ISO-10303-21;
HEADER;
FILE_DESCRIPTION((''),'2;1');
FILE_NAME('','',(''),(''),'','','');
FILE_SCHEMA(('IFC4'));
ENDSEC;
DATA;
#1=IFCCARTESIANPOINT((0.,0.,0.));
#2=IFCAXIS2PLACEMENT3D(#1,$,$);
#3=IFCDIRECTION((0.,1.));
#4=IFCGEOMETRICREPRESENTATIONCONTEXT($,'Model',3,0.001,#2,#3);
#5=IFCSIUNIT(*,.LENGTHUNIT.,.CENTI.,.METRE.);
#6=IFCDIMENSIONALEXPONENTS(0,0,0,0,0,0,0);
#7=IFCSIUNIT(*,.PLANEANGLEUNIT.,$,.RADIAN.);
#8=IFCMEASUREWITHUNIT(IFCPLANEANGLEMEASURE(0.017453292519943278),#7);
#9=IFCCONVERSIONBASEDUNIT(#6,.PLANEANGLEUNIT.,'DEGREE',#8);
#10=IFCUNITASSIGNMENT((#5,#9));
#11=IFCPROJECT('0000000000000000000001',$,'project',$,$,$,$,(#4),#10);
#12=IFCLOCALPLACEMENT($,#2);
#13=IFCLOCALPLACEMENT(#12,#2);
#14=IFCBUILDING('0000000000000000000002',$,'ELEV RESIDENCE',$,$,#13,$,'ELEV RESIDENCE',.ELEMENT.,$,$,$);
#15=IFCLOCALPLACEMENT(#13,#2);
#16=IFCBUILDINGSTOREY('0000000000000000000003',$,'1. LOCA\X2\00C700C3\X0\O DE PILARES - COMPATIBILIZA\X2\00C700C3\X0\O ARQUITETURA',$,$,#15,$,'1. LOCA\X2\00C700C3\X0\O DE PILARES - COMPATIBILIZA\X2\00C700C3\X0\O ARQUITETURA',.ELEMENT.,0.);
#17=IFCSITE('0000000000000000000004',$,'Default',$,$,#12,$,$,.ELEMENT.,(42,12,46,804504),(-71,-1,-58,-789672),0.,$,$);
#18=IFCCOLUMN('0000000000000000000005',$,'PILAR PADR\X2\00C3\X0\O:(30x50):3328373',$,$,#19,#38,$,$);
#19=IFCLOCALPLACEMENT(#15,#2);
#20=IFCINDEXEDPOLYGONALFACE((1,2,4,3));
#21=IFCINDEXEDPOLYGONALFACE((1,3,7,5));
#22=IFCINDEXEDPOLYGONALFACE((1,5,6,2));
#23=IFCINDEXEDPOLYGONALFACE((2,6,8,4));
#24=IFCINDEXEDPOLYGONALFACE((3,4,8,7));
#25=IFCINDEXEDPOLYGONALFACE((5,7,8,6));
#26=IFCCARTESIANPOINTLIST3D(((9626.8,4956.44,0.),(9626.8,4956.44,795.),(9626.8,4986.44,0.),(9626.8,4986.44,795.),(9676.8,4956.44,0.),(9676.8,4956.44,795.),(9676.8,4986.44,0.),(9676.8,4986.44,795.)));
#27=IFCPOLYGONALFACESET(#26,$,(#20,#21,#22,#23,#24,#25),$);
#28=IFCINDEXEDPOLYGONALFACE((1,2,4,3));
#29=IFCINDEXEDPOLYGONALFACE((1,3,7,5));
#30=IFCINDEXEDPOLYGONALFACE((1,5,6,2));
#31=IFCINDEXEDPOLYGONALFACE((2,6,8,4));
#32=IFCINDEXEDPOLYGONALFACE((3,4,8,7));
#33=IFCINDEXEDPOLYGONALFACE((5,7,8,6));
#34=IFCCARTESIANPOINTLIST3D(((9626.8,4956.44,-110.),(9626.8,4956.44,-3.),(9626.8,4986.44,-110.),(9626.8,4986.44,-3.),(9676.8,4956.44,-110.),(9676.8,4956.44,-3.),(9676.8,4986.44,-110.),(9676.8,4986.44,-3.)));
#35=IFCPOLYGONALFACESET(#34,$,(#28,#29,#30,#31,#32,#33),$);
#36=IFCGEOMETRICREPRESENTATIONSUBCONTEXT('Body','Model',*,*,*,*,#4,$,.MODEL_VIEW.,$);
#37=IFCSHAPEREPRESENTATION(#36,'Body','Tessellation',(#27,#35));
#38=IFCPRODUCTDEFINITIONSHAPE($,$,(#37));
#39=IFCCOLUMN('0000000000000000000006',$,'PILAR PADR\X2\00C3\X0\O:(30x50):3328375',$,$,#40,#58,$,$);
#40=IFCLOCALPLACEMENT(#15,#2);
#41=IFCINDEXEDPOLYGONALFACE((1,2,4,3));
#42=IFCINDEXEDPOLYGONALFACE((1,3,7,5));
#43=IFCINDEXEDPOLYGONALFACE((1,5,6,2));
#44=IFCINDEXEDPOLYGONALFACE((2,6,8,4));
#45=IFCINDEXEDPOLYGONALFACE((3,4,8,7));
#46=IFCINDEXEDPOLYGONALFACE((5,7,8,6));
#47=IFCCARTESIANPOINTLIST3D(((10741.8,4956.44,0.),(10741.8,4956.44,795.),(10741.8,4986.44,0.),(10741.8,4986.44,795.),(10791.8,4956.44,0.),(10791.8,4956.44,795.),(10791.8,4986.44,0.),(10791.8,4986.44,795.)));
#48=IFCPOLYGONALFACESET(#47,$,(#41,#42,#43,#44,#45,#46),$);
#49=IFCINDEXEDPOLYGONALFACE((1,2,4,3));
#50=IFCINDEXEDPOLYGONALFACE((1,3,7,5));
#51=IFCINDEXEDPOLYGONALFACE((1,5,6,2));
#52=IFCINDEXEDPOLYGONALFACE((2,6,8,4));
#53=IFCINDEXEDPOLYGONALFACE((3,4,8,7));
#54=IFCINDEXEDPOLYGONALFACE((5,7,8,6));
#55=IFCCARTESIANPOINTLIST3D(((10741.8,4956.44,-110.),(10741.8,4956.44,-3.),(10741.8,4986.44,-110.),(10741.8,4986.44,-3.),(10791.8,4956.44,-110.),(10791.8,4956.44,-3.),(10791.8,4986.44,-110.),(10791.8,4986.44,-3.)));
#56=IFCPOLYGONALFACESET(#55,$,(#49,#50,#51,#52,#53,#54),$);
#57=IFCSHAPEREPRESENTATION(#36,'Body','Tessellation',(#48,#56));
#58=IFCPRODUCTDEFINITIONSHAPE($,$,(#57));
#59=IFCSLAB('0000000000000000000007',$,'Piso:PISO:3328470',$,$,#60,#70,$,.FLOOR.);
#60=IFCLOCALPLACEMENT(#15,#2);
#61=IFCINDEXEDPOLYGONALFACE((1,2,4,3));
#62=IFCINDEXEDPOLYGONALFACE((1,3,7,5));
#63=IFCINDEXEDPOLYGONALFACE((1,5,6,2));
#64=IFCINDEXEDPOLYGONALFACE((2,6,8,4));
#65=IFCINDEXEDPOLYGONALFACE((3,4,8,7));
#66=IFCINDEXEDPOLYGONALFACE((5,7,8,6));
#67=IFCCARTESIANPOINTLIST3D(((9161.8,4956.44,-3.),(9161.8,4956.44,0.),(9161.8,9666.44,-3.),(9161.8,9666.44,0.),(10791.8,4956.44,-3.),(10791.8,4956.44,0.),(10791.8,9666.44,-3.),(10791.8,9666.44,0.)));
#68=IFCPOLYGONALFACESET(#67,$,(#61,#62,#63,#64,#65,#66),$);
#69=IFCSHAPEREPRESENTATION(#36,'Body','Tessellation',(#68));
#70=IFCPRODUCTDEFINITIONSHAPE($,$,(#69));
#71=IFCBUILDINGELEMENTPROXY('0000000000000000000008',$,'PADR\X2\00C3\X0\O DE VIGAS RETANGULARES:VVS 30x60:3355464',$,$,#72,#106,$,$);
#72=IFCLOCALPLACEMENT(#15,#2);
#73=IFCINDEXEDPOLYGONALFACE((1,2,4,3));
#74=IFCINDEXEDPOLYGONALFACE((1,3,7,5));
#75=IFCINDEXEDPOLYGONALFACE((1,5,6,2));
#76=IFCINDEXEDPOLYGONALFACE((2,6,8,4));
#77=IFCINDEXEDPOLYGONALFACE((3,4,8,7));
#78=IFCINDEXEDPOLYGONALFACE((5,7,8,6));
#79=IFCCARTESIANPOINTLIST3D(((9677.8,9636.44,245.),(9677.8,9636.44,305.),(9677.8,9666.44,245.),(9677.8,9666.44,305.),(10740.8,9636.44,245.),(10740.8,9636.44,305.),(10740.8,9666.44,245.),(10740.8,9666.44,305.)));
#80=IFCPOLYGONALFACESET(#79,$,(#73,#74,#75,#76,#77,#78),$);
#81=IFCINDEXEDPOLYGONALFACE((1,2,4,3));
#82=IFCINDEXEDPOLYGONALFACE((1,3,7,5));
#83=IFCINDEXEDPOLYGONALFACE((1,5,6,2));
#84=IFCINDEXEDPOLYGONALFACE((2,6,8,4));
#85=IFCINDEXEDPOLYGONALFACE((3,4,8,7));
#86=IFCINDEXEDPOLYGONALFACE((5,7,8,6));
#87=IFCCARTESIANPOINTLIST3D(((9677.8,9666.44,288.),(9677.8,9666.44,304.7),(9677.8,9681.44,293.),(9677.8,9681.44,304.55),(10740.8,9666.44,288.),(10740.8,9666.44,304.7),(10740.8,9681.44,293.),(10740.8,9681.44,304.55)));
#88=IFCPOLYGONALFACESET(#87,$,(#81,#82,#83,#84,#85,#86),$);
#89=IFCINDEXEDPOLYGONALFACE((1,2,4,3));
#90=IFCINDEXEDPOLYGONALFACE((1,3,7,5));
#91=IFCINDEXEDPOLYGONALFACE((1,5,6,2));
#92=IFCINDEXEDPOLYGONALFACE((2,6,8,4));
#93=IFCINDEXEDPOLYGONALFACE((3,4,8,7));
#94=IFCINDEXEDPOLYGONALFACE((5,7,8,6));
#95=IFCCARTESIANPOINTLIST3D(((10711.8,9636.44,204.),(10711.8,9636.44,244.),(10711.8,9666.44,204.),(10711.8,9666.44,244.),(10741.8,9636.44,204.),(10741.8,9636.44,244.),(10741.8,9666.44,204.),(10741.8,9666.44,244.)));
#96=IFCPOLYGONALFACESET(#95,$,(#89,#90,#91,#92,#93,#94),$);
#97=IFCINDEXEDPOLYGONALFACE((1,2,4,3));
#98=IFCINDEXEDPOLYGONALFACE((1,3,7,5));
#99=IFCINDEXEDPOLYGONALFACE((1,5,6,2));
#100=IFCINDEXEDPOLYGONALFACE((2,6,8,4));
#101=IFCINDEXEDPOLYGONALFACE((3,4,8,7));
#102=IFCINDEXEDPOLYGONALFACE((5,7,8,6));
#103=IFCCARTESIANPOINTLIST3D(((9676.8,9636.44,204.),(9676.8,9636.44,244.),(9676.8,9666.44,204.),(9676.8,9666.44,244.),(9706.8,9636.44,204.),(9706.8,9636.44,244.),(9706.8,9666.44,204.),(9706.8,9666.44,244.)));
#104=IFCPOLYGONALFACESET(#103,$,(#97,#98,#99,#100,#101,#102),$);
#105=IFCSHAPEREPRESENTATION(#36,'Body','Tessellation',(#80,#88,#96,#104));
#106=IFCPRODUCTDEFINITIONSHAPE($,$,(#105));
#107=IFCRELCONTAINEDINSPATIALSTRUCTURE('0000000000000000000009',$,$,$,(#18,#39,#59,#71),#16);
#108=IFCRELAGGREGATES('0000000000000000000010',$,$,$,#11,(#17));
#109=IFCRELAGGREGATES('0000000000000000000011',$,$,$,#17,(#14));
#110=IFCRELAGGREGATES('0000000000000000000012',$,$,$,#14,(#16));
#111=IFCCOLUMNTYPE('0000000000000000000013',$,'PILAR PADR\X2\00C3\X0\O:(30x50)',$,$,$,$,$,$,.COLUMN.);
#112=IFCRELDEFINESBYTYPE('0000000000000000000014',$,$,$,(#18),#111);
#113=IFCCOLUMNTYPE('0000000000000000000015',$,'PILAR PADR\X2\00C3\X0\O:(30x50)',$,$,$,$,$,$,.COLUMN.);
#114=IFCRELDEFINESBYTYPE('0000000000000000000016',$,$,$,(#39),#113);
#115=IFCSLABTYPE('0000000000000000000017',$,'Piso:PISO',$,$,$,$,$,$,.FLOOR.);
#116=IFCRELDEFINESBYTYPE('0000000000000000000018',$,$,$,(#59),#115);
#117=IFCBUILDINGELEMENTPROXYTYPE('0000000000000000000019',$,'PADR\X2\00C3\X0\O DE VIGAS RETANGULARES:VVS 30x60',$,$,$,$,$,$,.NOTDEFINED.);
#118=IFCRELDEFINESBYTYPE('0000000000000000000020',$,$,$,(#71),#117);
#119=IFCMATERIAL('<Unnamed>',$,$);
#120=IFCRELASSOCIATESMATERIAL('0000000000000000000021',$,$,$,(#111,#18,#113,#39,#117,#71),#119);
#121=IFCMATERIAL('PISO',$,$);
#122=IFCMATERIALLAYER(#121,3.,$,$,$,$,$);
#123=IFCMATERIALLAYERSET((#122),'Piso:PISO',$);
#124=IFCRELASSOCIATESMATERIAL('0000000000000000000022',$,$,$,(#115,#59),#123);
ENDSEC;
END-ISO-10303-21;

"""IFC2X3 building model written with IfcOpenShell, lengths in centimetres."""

from ifc_helpers import new_model, entity, si_unit, converted_unit, direction, frame, frame_2d, origin, origin_2d_with_axis, place, context, subcontext, project, spatial, polyline, rectangle, outline, extrude, source, transform, mapped, material, layer, layer_set, layer_usage, type_object, type_shapes, element, save


model = new_model("IFC2X3")

# Units and contexts
model_context = context("Model", 3, precision=0.001, world=origin(), true_north=direction((0.0, 1.0)))
body_context = subcontext(model_context, "Body", "Model", "MODEL_VIEW")
ifc_project = project(units=[si_unit("LENGTHUNIT", "METRE", prefix="CENTI"), converted_unit("PLANEANGLEUNIT", "DEGREE", entity("IfcPlaneAngleMeasure", 0.017453292519943278), si_unit("PLANEANGLEUNIT", "RADIAN"), dimensions=[0, 0, 0, 0, 0, 0, 0])], contexts=[model_context])

# Site, building, storey
site_placement = place(None, origin())
site = spatial("IfcSite", under=ifc_project, at=site_placement, Name="Default", CompositionType="ELEMENT", RefLatitude=(42, 12, 46, 804504), RefLongitude=(-71, -1, -58, -789672), RefElevation=0.0)
building_placement = place(site_placement, origin())
building = spatial("IfcBuilding", under=site, at=building_placement, Name="ELEV RESIDENCE", LongName="ELEV RESIDENCE", CompositionType="ELEMENT")
storey_placement = place(building_placement, origin())
storey = spatial("IfcBuildingStorey", under=building, at=storey_placement, Name="1. LOCAÇÃO DE PILARES - COMPATIBILIZAÇÃO ARQUITETURA", LongName="1. LOCAÇÃO DE PILARES - COMPATIBILIZAÇÃO ARQUITETURA", CompositionType="ELEMENT", Elevation=0.0)

# Columns
ifc_material_1 = material(Name="<Unnamed>")
column_type_1 = type_object("IfcColumnType", Name="PILAR PADRÃO:(30x50)", PredefinedType="COLUMN", material=ifc_material_1)
shared_shape_1 = source(origin(), body_context, "Body", "SweptSolid", [
    extrude(rectangle(XDim=795.0, YDim=30.0, at=origin_2d_with_axis()), frame((9626.8, 4971.44, 397.5), z_axis=(1.0, 0.0, 0.0), x_axis=(0.0, 0.0, -1.0)), (0.0, 0.0, 1.0), 50.0),
    extrude(rectangle(XDim=107.0, YDim=30.0, at=frame_2d((0.0, 0.0), x_axis=(1.0, 0.0))), frame((9626.8, 4971.44, -56.5), z_axis=(1.0, 0.0, 0.0), x_axis=(0.0, 0.0, 1.0)), (0.0, 0.0, 1.0), 50.0),
])
type_shapes(column_type_1, [shared_shape_1])
column_1_placement = place(storey_placement, origin())
element("IfcColumn", 1, at=column_1_placement, inside=storey, type_object=column_type_1, material=ifc_material_1, Name="PILAR PADRÃO:(30x50):3328373", context=body_context, shape_type="MappedRepresentation", body=[
    mapped(shared_shape_1, transform((0.0, 0.0, 0.0), scale=1.0)),
])
column_type_2 = type_object("IfcColumnType", Name="PILAR PADRÃO:(30x50)", PredefinedType="COLUMN", material=ifc_material_1)
shared_shape_2 = source(origin(), body_context, "Body", "SweptSolid", [
    extrude(rectangle(XDim=795.0, YDim=30.0, at=origin_2d_with_axis()), frame((10741.8, 4971.44, 397.5), z_axis=(1.0, 0.0, 0.0), x_axis=(0.0, 0.0, -1.0)), (0.0, 0.0, 1.0), 50.0),
    extrude(rectangle(XDim=107.0, YDim=30.0, at=frame_2d((0.0, 0.0), x_axis=(1.0, 0.0))), frame((10741.8, 4971.44, -56.5), z_axis=(1.0, 0.0, 0.0), x_axis=(0.0, 0.0, 1.0)), (0.0, 0.0, 1.0), 50.0),
])
type_shapes(column_type_2, [shared_shape_2])
column_2_placement = place(storey_placement, origin())
element("IfcColumn", 2, at=column_2_placement, inside=storey, type_object=column_type_2, material=ifc_material_1, Name="PILAR PADRÃO:(30x50):3328375", context=body_context, shape_type="MappedRepresentation", body=[
    mapped(shared_shape_2, transform((0.0, 0.0, 0.0), scale=1.0)),
])

# Slab
ifc_material_2 = material(Name="PISO")
ifc_layer = layer(ifc_material_2, 3.0)
ifc_layer_set = layer_set([ifc_layer], Name="Piso:PISO")
ifc_layer_usage = layer_usage(ifc_layer_set, "AXIS3", "POSITIVE", 0.0)
slab_type = type_object("IfcSlabType", Name="Piso:PISO", PredefinedType="FLOOR", material=ifc_layer_set)
slab_placement = place(storey_placement, origin())
element("IfcSlab", 3, at=slab_placement, inside=storey, type_object=slab_type, material=ifc_layer_usage, Name="Piso:PISO:3328470", PredefinedType="FLOOR", context=body_context, shape_type="SweptSolid", body=[
    extrude(rectangle(XDim=4710.0, YDim=1630.0, at=origin_2d_with_axis()), frame((9976.8, 7311.44, 0.0), z_axis=(0.0, 0.0, -1.0), x_axis=(0.0, 1.0, 0.0)), (0.0, 0.0, 1.0), 3.0),
])

# Building element proxy
building_element_proxy_type = type_object("IfcBuildingElementProxyType", Name="PADRÃO DE VIGAS RETANGULARES:VVS 30x60", PredefinedType="NOTDEFINED", material=ifc_material_1)
shared_shape_3 = source(origin(), body_context, "Body", "SweptSolid", [
    extrude(rectangle(XDim=1063.0, YDim=30.0, at=origin_2d_with_axis()), frame((10209.3, 9651.44, 245.0)), (0.0, 0.0, 1.0), 60.0),
    extrude(outline(polyline([(-4.56, -7.5), (6.99, -7.5), (7.14, 7.5), (-9.56, 7.5), (-4.56, -7.5)])), frame((9677.8, 9673.94, 297.56), z_axis=(1.0, 0.0, 0.0), x_axis=(0.0, 0.0, 1.0)), (0.0, 0.0, 1.0), 1063.0),
    extrude(rectangle(XDim=30.0, YDim=30.0, at=frame_2d((0.0, 0.0), x_axis=(1.0, 0.0))), frame((10726.8, 9651.44, 204.0), z_axis=(0.0, 0.0, 1.0), x_axis=(0.0, -1.0, 0.0)), (0.0, 0.0, 1.0), 40.0),
    extrude(rectangle(XDim=30.0, YDim=30.0, at=frame_2d((0.0, 0.0), x_axis=(1.0, 0.0))), frame((9691.8, 9651.44, 204.0), z_axis=(0.0, 0.0, 1.0), x_axis=(0.0, -1.0, 0.0)), (0.0, 0.0, 1.0), 40.0),
])
type_shapes(building_element_proxy_type, [shared_shape_3])
proxy_placement = place(storey_placement, origin())
element("IfcBuildingElementProxy", 4, at=proxy_placement, inside=storey, type_object=building_element_proxy_type, material=ifc_material_1, Name="PADRÃO DE VIGAS RETANGULARES:VVS 30x60:3355464", context=body_context, shape_type="MappedRepresentation", body=[
    mapped(shared_shape_3, transform((0.0, 0.0, 0.0), scale=1.0)),
])

save(model, "model.ifc")
